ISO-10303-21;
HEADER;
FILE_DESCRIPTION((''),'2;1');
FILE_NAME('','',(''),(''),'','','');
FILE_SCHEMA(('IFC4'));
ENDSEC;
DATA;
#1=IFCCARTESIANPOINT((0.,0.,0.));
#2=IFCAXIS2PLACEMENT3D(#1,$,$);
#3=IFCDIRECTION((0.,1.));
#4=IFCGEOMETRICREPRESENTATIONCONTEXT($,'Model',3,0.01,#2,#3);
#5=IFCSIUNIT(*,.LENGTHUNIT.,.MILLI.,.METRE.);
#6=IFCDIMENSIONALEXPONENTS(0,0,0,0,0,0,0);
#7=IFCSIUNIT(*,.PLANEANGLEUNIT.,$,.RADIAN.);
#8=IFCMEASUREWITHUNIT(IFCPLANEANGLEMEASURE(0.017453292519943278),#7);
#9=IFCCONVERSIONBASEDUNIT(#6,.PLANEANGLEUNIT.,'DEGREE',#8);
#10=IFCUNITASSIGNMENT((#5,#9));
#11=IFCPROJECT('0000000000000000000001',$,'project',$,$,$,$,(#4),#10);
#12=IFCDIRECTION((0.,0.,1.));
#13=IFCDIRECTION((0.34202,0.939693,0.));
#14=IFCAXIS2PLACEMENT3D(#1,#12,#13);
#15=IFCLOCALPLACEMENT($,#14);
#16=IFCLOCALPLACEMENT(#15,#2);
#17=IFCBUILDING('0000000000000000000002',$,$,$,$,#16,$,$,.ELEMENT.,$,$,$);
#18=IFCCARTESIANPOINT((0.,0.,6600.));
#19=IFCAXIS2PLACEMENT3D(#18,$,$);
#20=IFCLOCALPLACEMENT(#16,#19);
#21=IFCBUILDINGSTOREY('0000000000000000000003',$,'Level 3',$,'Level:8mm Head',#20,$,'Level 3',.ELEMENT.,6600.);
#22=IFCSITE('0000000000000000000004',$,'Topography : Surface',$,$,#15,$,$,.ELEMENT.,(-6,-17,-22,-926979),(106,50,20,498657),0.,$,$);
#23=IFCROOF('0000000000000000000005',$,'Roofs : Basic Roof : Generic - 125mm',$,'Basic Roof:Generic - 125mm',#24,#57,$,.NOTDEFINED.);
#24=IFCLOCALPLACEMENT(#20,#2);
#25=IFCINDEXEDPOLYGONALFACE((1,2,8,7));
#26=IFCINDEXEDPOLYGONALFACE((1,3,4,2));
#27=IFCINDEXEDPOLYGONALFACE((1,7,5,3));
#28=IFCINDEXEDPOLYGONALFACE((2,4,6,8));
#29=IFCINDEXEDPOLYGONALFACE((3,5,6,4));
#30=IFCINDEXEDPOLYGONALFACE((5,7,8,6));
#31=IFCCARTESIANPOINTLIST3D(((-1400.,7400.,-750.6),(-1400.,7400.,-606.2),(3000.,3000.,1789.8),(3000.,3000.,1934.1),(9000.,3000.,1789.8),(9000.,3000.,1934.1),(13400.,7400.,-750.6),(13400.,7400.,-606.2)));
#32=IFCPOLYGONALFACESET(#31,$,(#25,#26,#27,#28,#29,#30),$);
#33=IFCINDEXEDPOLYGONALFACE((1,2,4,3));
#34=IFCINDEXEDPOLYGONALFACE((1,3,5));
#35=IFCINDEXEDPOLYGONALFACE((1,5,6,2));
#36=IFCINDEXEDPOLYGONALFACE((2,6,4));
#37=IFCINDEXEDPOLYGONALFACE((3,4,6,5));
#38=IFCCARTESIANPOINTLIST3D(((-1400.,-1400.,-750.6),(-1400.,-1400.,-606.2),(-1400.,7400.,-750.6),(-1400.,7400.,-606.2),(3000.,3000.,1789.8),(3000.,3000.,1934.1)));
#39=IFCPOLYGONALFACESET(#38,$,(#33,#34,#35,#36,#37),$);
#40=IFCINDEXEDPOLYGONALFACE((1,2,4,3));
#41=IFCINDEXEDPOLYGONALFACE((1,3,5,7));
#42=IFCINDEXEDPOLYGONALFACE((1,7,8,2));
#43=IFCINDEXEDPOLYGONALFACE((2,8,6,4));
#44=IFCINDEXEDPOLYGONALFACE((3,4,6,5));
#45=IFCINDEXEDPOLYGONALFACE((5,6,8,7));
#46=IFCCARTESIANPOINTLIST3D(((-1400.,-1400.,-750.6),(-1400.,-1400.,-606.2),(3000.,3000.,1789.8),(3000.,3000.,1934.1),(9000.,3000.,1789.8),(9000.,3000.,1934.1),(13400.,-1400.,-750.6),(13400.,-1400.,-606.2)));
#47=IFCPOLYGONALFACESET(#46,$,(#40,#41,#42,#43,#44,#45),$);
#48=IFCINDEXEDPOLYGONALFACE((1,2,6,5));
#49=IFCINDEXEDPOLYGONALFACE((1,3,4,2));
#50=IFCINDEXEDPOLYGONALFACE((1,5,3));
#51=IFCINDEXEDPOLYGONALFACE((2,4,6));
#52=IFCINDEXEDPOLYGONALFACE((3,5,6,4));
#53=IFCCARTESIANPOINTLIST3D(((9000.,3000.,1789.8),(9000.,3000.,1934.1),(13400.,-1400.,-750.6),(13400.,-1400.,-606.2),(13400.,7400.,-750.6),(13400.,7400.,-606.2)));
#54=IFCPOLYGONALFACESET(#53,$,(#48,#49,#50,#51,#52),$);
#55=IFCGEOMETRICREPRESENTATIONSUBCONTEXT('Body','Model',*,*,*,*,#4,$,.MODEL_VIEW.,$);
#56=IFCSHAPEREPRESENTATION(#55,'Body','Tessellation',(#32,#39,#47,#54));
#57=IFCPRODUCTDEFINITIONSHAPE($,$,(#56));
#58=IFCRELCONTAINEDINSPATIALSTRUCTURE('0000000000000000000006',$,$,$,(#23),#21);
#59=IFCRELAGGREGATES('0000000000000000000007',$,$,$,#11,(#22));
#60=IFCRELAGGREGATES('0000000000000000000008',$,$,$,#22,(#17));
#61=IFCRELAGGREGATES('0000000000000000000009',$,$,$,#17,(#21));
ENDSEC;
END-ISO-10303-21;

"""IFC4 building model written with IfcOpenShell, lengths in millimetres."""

from ifc_helpers import new_model, entity, si_unit, converted_unit, direction, frame, origin, place, context, subcontext, project, spatial, indexed_curve, outline, extrude, element, save


model = new_model("IFC4")

# Units and contexts
model_context = context("Model", 3, precision=0.01, world=origin(), true_north=direction((0.0, 1.0)))
body_context = subcontext(model_context, "Body", "Model", "MODEL_VIEW")
ifc_project = project(units=[si_unit("LENGTHUNIT", "METRE", prefix="MILLI"), converted_unit("PLANEANGLEUNIT", "DEGREE", entity("IfcPlaneAngleMeasure", 0.017453292519943278), si_unit("PLANEANGLEUNIT", "RADIAN"), dimensions=[0, 0, 0, 0, 0, 0, 0])], contexts=[model_context])

# Site, building, storey
site_placement = place(None, frame((0.0, 0.0, 0.0), z_axis=(0.0, 0.0, 1.0), x_axis=(0.34202, 0.939693, 0.0)))
site = spatial("IfcSite", under=ifc_project, at=site_placement, Name="Topography : Surface", CompositionType="ELEMENT", RefLatitude=(-6, -17, -22, -926979), RefLongitude=(106, 50, 20, 498657), RefElevation=0.0)
building_placement = place(site_placement, origin())
building = spatial("IfcBuilding", under=site, at=building_placement, CompositionType="ELEMENT")
storey_placement = place(building_placement, frame((0.0, 0.0, 6600.0)))
storey = spatial("IfcBuildingStorey", under=building, at=storey_placement, Name="Level 3", ObjectType="Level:8mm Head", LongName="Level 3", CompositionType="ELEMENT", Elevation=6600.0)

# Roof
roof_placement = place(storey_placement, frame((-1400.0, -1400.0, -750.6)))
element("IfcRoof", 1, at=roof_placement, inside=storey, Name="Roofs : Basic Roof : Generic - 125mm", ObjectType="Basic Roof:Generic - 125mm", PredefinedType="NOTDEFINED", context=body_context, shape_type="SweptSolid", body=[
    extrude(outline(indexed_curve([(7400.0, 2540.3), (-7400.0, 2540.3), (-3000.0, -2540.3), (3000.0, -2540.3), (7400.0, 2540.3)], self_intersect=False)), frame((7400.0, 6600.0, 1270.2), z_axis=(0.0, 0.5, 0.866025), x_axis=(1.0, 0.0, 0.0)), (0.0, -0.5, 0.866025), 144.3),
    extrude(outline(indexed_curve([(-2540.3, 4400.0), (-2540.3, -4400.0), (2540.3, 0.0), (-2540.3, 4400.0)], self_intersect=False)), frame((2200.0, 4400.0, 1270.2), z_axis=(-0.5, 0.0, 0.866025), x_axis=(0.866025, 0.0, 0.5)), (0.5, 0.0, 0.866025), 144.3),
    extrude(outline(indexed_curve([(-7400.0, -2540.3), (7400.0, -2540.3), (3000.0, 2540.3), (-3000.0, 2540.3), (-7400.0, -2540.3)], self_intersect=False)), frame((7400.0, 2200.0, 1270.2), z_axis=(0.0, -0.5, 0.866025), x_axis=(1.0, 0.0, 0.0)), (0.0, 0.5, 0.866025), 144.3),
    extrude(outline(indexed_curve([(-2540.3, 0.0), (2540.3, -4400.0), (2540.3, 4400.0), (-2540.3, 0.0)], self_intersect=False)), frame((12600.0, 4400.0, 1270.2), z_axis=(0.5, 0.0, 0.866025), x_axis=(0.866025, 0.0, -0.5)), (-0.5, 0.0, 0.866025), 144.3),
])

save(model, "model.ifc")
